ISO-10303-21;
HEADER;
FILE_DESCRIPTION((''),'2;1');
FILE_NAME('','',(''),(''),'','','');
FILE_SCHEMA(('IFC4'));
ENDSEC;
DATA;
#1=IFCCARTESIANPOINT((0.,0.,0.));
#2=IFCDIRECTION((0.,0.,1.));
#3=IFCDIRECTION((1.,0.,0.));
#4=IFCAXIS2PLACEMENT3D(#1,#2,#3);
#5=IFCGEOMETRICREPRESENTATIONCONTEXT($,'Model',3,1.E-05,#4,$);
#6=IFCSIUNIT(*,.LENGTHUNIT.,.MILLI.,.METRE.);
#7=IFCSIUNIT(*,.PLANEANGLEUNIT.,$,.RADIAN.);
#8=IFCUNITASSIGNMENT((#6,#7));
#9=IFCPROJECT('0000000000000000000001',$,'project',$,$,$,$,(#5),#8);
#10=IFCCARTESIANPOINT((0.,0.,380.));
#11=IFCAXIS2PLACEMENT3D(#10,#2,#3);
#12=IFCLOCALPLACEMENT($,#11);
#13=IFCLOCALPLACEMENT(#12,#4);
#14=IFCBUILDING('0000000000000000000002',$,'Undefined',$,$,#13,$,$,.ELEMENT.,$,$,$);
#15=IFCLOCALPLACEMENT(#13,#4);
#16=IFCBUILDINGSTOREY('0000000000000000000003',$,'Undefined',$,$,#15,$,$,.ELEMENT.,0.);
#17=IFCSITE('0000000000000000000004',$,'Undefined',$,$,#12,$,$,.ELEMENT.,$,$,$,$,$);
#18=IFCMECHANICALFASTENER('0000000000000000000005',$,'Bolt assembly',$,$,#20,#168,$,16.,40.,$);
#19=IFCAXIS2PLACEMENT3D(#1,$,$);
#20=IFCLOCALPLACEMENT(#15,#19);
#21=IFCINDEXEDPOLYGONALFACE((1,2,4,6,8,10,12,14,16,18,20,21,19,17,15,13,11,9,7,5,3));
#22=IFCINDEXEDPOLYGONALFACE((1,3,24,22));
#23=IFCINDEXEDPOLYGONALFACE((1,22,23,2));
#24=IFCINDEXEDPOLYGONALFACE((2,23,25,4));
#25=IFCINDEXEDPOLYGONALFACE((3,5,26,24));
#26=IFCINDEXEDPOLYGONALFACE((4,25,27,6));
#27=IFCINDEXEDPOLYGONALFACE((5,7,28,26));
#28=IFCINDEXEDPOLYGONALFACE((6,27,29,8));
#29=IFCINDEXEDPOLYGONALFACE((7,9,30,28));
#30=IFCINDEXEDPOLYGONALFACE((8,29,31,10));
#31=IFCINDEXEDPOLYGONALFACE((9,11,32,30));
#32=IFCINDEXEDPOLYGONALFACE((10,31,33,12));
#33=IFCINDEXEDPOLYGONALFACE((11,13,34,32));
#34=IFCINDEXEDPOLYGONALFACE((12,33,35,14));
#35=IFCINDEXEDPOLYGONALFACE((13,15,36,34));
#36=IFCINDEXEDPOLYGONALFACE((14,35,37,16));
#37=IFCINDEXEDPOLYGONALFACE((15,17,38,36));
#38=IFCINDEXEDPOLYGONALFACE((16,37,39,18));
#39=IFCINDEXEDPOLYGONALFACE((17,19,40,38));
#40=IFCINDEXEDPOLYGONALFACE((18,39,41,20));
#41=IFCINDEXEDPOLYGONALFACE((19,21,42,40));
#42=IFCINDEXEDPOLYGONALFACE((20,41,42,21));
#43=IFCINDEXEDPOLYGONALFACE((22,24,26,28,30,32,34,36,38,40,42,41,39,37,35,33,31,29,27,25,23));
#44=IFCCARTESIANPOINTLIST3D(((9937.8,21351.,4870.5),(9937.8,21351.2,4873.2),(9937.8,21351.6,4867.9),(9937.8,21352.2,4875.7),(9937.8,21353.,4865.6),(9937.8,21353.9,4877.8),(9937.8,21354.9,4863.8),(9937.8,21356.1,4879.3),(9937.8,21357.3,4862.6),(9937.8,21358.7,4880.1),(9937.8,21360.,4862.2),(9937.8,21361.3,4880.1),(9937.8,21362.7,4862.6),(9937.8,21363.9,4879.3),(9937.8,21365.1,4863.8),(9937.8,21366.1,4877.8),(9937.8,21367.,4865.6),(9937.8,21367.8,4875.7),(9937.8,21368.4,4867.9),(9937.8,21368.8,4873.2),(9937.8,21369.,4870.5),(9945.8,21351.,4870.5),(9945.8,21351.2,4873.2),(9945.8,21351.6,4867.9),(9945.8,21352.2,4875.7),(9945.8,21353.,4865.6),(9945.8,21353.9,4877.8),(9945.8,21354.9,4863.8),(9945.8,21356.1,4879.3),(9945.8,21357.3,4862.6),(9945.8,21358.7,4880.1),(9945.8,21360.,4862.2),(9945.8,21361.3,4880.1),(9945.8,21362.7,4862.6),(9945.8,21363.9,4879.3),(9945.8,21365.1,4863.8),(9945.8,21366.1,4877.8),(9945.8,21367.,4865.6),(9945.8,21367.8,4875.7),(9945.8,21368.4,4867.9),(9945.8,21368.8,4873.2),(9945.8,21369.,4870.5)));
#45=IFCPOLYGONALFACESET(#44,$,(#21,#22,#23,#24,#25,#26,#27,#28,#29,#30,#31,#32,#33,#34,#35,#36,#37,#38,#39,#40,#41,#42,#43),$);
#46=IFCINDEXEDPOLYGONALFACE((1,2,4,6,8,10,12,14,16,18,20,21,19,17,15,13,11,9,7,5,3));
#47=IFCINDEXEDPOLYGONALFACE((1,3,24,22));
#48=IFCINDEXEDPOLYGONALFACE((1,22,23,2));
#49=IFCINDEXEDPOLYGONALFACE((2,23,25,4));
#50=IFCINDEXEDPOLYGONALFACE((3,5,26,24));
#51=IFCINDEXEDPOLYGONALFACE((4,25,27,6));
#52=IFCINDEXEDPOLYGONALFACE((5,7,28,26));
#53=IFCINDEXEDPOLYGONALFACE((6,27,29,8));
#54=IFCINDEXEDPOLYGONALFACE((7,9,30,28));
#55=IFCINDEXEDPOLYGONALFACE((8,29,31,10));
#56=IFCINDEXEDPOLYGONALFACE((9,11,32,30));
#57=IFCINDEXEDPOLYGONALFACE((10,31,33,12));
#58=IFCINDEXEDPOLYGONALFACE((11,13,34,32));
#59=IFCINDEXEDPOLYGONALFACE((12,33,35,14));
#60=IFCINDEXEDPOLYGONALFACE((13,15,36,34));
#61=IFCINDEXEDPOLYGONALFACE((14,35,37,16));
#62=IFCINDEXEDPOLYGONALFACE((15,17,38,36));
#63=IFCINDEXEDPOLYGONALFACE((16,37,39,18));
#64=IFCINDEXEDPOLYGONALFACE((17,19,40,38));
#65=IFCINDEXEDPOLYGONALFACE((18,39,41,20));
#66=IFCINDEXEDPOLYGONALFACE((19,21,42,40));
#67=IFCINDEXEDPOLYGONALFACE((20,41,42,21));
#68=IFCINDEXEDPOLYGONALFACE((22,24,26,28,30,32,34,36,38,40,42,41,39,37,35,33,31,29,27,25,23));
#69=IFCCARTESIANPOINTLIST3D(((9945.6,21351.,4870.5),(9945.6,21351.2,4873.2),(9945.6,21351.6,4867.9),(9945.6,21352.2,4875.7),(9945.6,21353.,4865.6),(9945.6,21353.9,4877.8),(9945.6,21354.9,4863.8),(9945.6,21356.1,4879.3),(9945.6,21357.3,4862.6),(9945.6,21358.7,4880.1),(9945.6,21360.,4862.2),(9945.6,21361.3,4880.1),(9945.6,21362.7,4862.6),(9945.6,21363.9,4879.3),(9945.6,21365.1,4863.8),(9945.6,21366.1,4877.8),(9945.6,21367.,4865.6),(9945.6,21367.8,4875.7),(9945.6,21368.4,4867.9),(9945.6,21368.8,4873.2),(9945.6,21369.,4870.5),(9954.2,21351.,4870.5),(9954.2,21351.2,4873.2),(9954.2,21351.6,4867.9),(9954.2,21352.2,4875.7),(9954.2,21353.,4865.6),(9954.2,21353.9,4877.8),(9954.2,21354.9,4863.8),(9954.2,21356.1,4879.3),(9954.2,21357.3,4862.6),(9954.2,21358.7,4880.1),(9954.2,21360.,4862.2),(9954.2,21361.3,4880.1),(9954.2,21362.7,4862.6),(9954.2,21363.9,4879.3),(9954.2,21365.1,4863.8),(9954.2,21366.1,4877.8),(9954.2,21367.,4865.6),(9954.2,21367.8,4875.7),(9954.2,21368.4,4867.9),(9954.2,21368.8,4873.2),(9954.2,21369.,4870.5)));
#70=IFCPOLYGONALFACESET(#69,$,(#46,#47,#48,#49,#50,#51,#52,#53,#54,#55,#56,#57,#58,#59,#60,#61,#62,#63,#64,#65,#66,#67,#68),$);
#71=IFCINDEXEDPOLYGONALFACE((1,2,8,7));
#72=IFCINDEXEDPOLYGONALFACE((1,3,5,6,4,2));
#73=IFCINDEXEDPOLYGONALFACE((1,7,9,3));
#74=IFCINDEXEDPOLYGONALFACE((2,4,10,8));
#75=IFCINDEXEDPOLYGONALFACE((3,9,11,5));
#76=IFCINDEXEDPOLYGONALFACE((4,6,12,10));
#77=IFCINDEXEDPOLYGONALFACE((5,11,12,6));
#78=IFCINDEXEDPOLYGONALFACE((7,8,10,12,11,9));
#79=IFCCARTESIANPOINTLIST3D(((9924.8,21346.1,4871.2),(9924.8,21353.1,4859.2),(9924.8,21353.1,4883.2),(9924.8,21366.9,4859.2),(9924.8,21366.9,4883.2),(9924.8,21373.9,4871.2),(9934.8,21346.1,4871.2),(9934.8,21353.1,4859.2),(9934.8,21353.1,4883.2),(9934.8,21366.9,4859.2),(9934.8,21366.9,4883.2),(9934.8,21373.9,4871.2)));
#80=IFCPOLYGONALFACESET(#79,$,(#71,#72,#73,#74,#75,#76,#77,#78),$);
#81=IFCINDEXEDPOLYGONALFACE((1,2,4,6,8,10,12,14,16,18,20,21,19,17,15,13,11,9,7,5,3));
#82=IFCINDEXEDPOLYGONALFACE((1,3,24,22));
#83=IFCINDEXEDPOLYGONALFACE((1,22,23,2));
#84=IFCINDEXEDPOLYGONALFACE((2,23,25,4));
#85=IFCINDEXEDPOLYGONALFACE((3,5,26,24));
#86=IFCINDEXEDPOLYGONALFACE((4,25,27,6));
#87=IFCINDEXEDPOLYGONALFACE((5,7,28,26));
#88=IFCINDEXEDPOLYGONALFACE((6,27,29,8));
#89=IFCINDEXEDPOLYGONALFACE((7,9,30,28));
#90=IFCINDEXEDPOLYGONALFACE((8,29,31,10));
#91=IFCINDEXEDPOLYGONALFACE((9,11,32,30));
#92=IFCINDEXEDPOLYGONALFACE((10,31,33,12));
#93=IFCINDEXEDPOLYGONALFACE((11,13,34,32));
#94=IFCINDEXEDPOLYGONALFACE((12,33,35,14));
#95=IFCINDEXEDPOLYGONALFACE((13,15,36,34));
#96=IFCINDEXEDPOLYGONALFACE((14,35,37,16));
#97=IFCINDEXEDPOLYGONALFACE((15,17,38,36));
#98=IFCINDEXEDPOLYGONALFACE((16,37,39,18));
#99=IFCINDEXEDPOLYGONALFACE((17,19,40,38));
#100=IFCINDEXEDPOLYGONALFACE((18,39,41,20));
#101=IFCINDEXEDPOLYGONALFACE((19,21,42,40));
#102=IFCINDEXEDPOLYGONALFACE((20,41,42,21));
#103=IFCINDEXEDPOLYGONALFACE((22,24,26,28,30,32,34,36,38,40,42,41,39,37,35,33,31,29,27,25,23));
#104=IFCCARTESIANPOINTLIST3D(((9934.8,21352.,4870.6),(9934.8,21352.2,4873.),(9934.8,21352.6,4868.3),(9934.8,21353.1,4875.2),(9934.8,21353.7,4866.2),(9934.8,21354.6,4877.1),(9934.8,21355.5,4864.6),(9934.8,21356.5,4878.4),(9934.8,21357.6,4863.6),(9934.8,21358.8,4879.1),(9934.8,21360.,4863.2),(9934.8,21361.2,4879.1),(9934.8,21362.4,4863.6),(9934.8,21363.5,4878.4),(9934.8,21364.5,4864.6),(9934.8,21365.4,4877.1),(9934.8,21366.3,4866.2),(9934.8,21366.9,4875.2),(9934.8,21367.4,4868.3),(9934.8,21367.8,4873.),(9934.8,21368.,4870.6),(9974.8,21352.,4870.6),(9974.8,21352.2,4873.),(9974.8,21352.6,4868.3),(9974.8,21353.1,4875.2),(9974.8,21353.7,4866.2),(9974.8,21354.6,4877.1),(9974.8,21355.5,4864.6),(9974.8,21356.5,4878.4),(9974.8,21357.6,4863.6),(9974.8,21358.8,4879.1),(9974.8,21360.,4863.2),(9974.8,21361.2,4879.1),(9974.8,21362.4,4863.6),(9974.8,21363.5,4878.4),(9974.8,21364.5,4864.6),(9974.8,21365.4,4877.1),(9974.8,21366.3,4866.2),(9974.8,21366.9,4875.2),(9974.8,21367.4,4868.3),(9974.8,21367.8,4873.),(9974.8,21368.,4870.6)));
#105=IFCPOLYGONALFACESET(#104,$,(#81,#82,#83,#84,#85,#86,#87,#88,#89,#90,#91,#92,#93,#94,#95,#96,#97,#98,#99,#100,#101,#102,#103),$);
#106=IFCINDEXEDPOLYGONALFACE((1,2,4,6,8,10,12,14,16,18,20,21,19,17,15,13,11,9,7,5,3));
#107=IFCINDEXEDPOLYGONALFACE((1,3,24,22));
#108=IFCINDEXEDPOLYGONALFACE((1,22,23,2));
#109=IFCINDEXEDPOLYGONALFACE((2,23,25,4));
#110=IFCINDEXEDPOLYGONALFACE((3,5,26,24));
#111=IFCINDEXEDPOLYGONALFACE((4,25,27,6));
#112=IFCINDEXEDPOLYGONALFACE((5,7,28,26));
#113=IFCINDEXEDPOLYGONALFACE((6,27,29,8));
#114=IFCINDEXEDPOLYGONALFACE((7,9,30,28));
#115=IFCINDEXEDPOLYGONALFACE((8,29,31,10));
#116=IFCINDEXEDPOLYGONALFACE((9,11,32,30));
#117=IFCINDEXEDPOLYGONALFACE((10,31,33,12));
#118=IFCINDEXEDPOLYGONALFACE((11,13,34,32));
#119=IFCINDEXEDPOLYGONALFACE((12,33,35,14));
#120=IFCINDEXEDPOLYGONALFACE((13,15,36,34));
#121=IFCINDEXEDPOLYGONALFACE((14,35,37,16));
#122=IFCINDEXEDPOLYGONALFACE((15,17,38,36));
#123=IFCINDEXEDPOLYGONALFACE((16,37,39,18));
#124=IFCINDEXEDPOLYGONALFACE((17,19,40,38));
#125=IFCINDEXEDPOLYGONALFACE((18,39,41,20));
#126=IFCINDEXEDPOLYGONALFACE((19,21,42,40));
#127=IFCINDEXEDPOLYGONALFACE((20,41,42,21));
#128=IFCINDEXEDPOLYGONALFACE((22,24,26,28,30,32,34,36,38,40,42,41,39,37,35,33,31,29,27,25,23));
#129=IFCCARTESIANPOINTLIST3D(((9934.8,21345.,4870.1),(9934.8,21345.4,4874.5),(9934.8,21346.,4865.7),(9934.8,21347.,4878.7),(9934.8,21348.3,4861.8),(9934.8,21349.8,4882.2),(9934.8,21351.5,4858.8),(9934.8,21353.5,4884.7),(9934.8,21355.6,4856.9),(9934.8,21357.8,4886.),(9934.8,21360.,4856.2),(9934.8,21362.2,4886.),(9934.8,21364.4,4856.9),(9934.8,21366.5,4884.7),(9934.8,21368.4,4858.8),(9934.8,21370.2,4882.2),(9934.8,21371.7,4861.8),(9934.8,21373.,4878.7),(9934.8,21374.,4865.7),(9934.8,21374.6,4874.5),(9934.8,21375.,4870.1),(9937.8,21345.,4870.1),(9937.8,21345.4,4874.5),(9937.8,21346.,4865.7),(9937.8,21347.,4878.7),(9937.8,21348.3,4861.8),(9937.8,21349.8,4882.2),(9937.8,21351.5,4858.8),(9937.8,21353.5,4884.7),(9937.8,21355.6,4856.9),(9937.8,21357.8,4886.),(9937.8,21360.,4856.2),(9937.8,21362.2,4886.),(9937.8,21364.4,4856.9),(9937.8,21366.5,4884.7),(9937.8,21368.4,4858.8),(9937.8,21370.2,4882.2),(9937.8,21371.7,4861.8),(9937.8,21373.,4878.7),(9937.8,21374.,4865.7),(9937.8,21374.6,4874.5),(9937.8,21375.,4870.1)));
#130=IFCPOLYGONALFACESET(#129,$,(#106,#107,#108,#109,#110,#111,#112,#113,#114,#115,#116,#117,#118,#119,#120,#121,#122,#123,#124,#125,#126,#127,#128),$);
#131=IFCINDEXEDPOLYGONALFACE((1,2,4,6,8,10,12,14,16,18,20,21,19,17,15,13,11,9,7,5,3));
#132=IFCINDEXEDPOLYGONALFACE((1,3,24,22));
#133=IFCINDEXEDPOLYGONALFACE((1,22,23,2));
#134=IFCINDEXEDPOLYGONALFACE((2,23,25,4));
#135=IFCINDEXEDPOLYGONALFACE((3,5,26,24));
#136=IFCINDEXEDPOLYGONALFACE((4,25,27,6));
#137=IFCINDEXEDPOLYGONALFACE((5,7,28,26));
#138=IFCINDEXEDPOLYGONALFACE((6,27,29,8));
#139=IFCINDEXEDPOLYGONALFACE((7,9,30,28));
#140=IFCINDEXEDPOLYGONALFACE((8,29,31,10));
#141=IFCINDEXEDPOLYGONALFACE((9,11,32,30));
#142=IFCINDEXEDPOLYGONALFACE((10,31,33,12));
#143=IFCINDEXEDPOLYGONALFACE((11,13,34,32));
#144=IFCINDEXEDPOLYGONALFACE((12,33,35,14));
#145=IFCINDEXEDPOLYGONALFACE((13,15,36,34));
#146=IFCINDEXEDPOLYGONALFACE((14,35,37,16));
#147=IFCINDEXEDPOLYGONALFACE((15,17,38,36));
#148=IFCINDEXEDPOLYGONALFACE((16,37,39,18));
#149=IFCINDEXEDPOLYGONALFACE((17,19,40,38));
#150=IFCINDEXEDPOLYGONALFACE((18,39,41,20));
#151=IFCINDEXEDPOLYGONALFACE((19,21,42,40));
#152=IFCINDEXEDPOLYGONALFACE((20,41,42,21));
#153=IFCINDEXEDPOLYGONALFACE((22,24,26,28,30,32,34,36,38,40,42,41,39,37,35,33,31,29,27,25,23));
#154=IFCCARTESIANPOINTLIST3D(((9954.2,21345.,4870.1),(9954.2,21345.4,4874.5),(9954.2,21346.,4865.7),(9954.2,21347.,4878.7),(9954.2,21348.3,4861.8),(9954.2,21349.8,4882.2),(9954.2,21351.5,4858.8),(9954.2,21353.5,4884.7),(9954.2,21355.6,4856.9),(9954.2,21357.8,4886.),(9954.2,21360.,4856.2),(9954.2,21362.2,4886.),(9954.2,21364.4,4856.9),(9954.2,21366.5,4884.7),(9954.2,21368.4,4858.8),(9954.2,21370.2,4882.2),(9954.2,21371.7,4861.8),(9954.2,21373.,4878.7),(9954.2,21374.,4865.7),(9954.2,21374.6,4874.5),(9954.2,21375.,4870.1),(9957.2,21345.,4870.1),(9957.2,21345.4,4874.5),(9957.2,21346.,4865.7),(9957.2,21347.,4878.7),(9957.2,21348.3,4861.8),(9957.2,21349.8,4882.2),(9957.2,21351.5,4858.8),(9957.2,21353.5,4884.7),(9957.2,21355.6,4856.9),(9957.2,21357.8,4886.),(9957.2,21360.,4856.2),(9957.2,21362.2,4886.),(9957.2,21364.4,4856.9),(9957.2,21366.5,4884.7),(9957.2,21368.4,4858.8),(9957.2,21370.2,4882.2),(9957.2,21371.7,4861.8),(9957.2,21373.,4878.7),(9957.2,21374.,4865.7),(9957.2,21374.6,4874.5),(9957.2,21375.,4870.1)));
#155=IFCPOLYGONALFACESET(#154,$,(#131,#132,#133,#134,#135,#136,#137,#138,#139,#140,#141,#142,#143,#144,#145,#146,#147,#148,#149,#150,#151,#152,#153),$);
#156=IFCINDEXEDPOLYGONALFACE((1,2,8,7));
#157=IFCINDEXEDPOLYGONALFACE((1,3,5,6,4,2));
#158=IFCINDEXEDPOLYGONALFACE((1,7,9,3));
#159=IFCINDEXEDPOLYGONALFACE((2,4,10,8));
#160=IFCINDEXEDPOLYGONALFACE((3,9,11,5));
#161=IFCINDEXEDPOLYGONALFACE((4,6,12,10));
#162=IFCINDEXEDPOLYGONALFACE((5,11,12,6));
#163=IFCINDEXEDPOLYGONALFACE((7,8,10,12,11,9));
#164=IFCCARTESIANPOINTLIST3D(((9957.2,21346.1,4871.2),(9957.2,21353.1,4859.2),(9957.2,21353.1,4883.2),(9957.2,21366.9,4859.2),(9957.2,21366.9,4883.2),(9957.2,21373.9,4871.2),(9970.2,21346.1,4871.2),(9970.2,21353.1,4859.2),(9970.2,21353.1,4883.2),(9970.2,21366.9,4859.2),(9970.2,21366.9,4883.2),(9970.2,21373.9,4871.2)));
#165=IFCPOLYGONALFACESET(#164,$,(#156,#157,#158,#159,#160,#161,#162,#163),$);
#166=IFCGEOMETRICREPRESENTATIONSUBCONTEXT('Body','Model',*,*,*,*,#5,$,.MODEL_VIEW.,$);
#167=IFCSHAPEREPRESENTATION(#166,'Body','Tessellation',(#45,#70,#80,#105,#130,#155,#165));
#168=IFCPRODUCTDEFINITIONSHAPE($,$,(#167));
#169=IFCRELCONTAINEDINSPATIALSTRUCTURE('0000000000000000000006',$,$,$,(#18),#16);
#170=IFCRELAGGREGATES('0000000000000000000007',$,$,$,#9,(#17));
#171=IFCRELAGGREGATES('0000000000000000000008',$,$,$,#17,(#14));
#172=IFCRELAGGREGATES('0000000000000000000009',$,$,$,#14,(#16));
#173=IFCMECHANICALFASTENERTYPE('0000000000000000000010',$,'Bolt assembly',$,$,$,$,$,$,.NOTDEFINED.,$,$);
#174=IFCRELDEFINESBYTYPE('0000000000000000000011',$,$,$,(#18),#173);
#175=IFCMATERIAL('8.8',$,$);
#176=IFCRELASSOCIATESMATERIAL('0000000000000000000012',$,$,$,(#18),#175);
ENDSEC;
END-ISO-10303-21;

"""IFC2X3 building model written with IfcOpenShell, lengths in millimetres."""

from ifc_helpers import new_model, si_unit, frame, origin_with_axes, origin_2d_with_axis, place, context, subcontext, project, spatial, polyline, circle, outline, extrude, source, transform, mapped, material, type_object, element, save


model = new_model("IFC2X3")

# Units and contexts
model_context = context("Model", 3, precision=1e-05, world=origin_with_axes())
body_context = subcontext(model_context, "Body", "Model", "MODEL_VIEW")
ifc_project = project(units=[si_unit("LENGTHUNIT", "METRE", prefix="MILLI"), si_unit("PLANEANGLEUNIT", "RADIAN")], contexts=[model_context])

# Site, building, storey
site_placement = place(None, frame((0.0, 0.0, 380.0), z_axis=(0.0, 0.0, 1.0), x_axis=(1.0, 0.0, 0.0)))
site = spatial("IfcSite", under=ifc_project, at=site_placement, Name="Undefined", CompositionType="ELEMENT")
building_placement = place(site_placement, origin_with_axes())
building = spatial("IfcBuilding", under=site, at=building_placement, Name="Undefined", CompositionType="ELEMENT")
storey_placement = place(building_placement, origin_with_axes())
storey = spatial("IfcBuildingStorey", under=building, at=storey_placement, Name="Undefined", CompositionType="ELEMENT", Elevation=0.0)

# Mechanical fastener
ifc_material_1 = material(Name="8.8")
mechanical_fastener_type = type_object("IfcMechanicalFastenerType", Name="Bolt assembly")
shared_shape_1 = source(origin_with_axes(), body_context, "Body", "SweptSolid", [
    extrude(circle(Radius=9.0, at=origin_2d_with_axis()), frame((0.0, -7.9, 0.0), z_axis=(0.0, 1.0, 0.0), x_axis=(1.0, 0.0, 0.0)), (0.0, 0.0, 1.0), 8.0),
    extrude(circle(Radius=9.0, at=origin_2d_with_axis()), frame((0.0, -0.1, 0.0), z_axis=(0.0, 1.0, 0.0), x_axis=(1.0, 0.0, 0.0)), (0.0, 0.0, 1.0), 8.6),
    extrude(outline(polyline([(12.0, -6.9), (12.0, 6.9), (0.0, 13.9), (-12.0, 6.9), (-12.0, -6.9), (0.0, -13.9), (12.0, -6.9)])), frame((0.0, -21.0, 0.0), z_axis=(0.0, 1.0, 0.0), x_axis=(1.0, 0.0, 0.0)), (0.0, 0.0, 1.0), 10.0),
    extrude(circle(Radius=8.0, at=origin_2d_with_axis()), frame((0.0, -11.0, 0.0), z_axis=(0.0, 1.0, 0.0), x_axis=(1.0, 0.0, 0.0)), (0.0, 0.0, 1.0), 40.0),
    extrude(circle(Radius=15.0, at=origin_2d_with_axis()), frame((0.0, -11.0, 0.0), z_axis=(0.0, 1.0, 0.0), x_axis=(1.0, 0.0, 0.0)), (0.0, 0.0, 1.0), 3.0),
    extrude(circle(Radius=15.0, at=origin_2d_with_axis()), frame((0.0, 8.5, 0.0), z_axis=(0.0, 1.0, 0.0), x_axis=(1.0, 0.0, 0.0)), (0.0, 0.0, 1.0), 3.0),
    extrude(outline(polyline([(12.0, -6.9), (12.0, 6.9), (0.0, 13.9), (-12.0, 6.9), (-12.0, -6.9), (0.0, -13.9), (12.0, -6.9)])), frame((0.0, 11.5, 0.0), z_axis=(0.0, 1.0, 0.0), x_axis=(1.0, 0.0, 0.0)), (0.0, 0.0, 1.0), 13.0),
])
for number, where, z_axis, x_axis, name in (
    (1, (9945.8, 21397.5, 4951.2), (0.0, -1.0, 0.0), (0.0, 0.0, -1.0), "Bolt assembly"),
):
    element("IfcMechanicalFastener", number, at=place(storey_placement, frame(where, z_axis=z_axis, x_axis=x_axis)), inside=storey, type_object=mechanical_fastener_type, material=ifc_material_1, Name=name, NominalDiameter=16.0, NominalLength=40.0, context=body_context, shape_type="MappedRepresentation", body=[
        mapped(shared_shape_1, transform((80.0, 0.0, 37.5))),
    ])

save(model, "model.ifc")
